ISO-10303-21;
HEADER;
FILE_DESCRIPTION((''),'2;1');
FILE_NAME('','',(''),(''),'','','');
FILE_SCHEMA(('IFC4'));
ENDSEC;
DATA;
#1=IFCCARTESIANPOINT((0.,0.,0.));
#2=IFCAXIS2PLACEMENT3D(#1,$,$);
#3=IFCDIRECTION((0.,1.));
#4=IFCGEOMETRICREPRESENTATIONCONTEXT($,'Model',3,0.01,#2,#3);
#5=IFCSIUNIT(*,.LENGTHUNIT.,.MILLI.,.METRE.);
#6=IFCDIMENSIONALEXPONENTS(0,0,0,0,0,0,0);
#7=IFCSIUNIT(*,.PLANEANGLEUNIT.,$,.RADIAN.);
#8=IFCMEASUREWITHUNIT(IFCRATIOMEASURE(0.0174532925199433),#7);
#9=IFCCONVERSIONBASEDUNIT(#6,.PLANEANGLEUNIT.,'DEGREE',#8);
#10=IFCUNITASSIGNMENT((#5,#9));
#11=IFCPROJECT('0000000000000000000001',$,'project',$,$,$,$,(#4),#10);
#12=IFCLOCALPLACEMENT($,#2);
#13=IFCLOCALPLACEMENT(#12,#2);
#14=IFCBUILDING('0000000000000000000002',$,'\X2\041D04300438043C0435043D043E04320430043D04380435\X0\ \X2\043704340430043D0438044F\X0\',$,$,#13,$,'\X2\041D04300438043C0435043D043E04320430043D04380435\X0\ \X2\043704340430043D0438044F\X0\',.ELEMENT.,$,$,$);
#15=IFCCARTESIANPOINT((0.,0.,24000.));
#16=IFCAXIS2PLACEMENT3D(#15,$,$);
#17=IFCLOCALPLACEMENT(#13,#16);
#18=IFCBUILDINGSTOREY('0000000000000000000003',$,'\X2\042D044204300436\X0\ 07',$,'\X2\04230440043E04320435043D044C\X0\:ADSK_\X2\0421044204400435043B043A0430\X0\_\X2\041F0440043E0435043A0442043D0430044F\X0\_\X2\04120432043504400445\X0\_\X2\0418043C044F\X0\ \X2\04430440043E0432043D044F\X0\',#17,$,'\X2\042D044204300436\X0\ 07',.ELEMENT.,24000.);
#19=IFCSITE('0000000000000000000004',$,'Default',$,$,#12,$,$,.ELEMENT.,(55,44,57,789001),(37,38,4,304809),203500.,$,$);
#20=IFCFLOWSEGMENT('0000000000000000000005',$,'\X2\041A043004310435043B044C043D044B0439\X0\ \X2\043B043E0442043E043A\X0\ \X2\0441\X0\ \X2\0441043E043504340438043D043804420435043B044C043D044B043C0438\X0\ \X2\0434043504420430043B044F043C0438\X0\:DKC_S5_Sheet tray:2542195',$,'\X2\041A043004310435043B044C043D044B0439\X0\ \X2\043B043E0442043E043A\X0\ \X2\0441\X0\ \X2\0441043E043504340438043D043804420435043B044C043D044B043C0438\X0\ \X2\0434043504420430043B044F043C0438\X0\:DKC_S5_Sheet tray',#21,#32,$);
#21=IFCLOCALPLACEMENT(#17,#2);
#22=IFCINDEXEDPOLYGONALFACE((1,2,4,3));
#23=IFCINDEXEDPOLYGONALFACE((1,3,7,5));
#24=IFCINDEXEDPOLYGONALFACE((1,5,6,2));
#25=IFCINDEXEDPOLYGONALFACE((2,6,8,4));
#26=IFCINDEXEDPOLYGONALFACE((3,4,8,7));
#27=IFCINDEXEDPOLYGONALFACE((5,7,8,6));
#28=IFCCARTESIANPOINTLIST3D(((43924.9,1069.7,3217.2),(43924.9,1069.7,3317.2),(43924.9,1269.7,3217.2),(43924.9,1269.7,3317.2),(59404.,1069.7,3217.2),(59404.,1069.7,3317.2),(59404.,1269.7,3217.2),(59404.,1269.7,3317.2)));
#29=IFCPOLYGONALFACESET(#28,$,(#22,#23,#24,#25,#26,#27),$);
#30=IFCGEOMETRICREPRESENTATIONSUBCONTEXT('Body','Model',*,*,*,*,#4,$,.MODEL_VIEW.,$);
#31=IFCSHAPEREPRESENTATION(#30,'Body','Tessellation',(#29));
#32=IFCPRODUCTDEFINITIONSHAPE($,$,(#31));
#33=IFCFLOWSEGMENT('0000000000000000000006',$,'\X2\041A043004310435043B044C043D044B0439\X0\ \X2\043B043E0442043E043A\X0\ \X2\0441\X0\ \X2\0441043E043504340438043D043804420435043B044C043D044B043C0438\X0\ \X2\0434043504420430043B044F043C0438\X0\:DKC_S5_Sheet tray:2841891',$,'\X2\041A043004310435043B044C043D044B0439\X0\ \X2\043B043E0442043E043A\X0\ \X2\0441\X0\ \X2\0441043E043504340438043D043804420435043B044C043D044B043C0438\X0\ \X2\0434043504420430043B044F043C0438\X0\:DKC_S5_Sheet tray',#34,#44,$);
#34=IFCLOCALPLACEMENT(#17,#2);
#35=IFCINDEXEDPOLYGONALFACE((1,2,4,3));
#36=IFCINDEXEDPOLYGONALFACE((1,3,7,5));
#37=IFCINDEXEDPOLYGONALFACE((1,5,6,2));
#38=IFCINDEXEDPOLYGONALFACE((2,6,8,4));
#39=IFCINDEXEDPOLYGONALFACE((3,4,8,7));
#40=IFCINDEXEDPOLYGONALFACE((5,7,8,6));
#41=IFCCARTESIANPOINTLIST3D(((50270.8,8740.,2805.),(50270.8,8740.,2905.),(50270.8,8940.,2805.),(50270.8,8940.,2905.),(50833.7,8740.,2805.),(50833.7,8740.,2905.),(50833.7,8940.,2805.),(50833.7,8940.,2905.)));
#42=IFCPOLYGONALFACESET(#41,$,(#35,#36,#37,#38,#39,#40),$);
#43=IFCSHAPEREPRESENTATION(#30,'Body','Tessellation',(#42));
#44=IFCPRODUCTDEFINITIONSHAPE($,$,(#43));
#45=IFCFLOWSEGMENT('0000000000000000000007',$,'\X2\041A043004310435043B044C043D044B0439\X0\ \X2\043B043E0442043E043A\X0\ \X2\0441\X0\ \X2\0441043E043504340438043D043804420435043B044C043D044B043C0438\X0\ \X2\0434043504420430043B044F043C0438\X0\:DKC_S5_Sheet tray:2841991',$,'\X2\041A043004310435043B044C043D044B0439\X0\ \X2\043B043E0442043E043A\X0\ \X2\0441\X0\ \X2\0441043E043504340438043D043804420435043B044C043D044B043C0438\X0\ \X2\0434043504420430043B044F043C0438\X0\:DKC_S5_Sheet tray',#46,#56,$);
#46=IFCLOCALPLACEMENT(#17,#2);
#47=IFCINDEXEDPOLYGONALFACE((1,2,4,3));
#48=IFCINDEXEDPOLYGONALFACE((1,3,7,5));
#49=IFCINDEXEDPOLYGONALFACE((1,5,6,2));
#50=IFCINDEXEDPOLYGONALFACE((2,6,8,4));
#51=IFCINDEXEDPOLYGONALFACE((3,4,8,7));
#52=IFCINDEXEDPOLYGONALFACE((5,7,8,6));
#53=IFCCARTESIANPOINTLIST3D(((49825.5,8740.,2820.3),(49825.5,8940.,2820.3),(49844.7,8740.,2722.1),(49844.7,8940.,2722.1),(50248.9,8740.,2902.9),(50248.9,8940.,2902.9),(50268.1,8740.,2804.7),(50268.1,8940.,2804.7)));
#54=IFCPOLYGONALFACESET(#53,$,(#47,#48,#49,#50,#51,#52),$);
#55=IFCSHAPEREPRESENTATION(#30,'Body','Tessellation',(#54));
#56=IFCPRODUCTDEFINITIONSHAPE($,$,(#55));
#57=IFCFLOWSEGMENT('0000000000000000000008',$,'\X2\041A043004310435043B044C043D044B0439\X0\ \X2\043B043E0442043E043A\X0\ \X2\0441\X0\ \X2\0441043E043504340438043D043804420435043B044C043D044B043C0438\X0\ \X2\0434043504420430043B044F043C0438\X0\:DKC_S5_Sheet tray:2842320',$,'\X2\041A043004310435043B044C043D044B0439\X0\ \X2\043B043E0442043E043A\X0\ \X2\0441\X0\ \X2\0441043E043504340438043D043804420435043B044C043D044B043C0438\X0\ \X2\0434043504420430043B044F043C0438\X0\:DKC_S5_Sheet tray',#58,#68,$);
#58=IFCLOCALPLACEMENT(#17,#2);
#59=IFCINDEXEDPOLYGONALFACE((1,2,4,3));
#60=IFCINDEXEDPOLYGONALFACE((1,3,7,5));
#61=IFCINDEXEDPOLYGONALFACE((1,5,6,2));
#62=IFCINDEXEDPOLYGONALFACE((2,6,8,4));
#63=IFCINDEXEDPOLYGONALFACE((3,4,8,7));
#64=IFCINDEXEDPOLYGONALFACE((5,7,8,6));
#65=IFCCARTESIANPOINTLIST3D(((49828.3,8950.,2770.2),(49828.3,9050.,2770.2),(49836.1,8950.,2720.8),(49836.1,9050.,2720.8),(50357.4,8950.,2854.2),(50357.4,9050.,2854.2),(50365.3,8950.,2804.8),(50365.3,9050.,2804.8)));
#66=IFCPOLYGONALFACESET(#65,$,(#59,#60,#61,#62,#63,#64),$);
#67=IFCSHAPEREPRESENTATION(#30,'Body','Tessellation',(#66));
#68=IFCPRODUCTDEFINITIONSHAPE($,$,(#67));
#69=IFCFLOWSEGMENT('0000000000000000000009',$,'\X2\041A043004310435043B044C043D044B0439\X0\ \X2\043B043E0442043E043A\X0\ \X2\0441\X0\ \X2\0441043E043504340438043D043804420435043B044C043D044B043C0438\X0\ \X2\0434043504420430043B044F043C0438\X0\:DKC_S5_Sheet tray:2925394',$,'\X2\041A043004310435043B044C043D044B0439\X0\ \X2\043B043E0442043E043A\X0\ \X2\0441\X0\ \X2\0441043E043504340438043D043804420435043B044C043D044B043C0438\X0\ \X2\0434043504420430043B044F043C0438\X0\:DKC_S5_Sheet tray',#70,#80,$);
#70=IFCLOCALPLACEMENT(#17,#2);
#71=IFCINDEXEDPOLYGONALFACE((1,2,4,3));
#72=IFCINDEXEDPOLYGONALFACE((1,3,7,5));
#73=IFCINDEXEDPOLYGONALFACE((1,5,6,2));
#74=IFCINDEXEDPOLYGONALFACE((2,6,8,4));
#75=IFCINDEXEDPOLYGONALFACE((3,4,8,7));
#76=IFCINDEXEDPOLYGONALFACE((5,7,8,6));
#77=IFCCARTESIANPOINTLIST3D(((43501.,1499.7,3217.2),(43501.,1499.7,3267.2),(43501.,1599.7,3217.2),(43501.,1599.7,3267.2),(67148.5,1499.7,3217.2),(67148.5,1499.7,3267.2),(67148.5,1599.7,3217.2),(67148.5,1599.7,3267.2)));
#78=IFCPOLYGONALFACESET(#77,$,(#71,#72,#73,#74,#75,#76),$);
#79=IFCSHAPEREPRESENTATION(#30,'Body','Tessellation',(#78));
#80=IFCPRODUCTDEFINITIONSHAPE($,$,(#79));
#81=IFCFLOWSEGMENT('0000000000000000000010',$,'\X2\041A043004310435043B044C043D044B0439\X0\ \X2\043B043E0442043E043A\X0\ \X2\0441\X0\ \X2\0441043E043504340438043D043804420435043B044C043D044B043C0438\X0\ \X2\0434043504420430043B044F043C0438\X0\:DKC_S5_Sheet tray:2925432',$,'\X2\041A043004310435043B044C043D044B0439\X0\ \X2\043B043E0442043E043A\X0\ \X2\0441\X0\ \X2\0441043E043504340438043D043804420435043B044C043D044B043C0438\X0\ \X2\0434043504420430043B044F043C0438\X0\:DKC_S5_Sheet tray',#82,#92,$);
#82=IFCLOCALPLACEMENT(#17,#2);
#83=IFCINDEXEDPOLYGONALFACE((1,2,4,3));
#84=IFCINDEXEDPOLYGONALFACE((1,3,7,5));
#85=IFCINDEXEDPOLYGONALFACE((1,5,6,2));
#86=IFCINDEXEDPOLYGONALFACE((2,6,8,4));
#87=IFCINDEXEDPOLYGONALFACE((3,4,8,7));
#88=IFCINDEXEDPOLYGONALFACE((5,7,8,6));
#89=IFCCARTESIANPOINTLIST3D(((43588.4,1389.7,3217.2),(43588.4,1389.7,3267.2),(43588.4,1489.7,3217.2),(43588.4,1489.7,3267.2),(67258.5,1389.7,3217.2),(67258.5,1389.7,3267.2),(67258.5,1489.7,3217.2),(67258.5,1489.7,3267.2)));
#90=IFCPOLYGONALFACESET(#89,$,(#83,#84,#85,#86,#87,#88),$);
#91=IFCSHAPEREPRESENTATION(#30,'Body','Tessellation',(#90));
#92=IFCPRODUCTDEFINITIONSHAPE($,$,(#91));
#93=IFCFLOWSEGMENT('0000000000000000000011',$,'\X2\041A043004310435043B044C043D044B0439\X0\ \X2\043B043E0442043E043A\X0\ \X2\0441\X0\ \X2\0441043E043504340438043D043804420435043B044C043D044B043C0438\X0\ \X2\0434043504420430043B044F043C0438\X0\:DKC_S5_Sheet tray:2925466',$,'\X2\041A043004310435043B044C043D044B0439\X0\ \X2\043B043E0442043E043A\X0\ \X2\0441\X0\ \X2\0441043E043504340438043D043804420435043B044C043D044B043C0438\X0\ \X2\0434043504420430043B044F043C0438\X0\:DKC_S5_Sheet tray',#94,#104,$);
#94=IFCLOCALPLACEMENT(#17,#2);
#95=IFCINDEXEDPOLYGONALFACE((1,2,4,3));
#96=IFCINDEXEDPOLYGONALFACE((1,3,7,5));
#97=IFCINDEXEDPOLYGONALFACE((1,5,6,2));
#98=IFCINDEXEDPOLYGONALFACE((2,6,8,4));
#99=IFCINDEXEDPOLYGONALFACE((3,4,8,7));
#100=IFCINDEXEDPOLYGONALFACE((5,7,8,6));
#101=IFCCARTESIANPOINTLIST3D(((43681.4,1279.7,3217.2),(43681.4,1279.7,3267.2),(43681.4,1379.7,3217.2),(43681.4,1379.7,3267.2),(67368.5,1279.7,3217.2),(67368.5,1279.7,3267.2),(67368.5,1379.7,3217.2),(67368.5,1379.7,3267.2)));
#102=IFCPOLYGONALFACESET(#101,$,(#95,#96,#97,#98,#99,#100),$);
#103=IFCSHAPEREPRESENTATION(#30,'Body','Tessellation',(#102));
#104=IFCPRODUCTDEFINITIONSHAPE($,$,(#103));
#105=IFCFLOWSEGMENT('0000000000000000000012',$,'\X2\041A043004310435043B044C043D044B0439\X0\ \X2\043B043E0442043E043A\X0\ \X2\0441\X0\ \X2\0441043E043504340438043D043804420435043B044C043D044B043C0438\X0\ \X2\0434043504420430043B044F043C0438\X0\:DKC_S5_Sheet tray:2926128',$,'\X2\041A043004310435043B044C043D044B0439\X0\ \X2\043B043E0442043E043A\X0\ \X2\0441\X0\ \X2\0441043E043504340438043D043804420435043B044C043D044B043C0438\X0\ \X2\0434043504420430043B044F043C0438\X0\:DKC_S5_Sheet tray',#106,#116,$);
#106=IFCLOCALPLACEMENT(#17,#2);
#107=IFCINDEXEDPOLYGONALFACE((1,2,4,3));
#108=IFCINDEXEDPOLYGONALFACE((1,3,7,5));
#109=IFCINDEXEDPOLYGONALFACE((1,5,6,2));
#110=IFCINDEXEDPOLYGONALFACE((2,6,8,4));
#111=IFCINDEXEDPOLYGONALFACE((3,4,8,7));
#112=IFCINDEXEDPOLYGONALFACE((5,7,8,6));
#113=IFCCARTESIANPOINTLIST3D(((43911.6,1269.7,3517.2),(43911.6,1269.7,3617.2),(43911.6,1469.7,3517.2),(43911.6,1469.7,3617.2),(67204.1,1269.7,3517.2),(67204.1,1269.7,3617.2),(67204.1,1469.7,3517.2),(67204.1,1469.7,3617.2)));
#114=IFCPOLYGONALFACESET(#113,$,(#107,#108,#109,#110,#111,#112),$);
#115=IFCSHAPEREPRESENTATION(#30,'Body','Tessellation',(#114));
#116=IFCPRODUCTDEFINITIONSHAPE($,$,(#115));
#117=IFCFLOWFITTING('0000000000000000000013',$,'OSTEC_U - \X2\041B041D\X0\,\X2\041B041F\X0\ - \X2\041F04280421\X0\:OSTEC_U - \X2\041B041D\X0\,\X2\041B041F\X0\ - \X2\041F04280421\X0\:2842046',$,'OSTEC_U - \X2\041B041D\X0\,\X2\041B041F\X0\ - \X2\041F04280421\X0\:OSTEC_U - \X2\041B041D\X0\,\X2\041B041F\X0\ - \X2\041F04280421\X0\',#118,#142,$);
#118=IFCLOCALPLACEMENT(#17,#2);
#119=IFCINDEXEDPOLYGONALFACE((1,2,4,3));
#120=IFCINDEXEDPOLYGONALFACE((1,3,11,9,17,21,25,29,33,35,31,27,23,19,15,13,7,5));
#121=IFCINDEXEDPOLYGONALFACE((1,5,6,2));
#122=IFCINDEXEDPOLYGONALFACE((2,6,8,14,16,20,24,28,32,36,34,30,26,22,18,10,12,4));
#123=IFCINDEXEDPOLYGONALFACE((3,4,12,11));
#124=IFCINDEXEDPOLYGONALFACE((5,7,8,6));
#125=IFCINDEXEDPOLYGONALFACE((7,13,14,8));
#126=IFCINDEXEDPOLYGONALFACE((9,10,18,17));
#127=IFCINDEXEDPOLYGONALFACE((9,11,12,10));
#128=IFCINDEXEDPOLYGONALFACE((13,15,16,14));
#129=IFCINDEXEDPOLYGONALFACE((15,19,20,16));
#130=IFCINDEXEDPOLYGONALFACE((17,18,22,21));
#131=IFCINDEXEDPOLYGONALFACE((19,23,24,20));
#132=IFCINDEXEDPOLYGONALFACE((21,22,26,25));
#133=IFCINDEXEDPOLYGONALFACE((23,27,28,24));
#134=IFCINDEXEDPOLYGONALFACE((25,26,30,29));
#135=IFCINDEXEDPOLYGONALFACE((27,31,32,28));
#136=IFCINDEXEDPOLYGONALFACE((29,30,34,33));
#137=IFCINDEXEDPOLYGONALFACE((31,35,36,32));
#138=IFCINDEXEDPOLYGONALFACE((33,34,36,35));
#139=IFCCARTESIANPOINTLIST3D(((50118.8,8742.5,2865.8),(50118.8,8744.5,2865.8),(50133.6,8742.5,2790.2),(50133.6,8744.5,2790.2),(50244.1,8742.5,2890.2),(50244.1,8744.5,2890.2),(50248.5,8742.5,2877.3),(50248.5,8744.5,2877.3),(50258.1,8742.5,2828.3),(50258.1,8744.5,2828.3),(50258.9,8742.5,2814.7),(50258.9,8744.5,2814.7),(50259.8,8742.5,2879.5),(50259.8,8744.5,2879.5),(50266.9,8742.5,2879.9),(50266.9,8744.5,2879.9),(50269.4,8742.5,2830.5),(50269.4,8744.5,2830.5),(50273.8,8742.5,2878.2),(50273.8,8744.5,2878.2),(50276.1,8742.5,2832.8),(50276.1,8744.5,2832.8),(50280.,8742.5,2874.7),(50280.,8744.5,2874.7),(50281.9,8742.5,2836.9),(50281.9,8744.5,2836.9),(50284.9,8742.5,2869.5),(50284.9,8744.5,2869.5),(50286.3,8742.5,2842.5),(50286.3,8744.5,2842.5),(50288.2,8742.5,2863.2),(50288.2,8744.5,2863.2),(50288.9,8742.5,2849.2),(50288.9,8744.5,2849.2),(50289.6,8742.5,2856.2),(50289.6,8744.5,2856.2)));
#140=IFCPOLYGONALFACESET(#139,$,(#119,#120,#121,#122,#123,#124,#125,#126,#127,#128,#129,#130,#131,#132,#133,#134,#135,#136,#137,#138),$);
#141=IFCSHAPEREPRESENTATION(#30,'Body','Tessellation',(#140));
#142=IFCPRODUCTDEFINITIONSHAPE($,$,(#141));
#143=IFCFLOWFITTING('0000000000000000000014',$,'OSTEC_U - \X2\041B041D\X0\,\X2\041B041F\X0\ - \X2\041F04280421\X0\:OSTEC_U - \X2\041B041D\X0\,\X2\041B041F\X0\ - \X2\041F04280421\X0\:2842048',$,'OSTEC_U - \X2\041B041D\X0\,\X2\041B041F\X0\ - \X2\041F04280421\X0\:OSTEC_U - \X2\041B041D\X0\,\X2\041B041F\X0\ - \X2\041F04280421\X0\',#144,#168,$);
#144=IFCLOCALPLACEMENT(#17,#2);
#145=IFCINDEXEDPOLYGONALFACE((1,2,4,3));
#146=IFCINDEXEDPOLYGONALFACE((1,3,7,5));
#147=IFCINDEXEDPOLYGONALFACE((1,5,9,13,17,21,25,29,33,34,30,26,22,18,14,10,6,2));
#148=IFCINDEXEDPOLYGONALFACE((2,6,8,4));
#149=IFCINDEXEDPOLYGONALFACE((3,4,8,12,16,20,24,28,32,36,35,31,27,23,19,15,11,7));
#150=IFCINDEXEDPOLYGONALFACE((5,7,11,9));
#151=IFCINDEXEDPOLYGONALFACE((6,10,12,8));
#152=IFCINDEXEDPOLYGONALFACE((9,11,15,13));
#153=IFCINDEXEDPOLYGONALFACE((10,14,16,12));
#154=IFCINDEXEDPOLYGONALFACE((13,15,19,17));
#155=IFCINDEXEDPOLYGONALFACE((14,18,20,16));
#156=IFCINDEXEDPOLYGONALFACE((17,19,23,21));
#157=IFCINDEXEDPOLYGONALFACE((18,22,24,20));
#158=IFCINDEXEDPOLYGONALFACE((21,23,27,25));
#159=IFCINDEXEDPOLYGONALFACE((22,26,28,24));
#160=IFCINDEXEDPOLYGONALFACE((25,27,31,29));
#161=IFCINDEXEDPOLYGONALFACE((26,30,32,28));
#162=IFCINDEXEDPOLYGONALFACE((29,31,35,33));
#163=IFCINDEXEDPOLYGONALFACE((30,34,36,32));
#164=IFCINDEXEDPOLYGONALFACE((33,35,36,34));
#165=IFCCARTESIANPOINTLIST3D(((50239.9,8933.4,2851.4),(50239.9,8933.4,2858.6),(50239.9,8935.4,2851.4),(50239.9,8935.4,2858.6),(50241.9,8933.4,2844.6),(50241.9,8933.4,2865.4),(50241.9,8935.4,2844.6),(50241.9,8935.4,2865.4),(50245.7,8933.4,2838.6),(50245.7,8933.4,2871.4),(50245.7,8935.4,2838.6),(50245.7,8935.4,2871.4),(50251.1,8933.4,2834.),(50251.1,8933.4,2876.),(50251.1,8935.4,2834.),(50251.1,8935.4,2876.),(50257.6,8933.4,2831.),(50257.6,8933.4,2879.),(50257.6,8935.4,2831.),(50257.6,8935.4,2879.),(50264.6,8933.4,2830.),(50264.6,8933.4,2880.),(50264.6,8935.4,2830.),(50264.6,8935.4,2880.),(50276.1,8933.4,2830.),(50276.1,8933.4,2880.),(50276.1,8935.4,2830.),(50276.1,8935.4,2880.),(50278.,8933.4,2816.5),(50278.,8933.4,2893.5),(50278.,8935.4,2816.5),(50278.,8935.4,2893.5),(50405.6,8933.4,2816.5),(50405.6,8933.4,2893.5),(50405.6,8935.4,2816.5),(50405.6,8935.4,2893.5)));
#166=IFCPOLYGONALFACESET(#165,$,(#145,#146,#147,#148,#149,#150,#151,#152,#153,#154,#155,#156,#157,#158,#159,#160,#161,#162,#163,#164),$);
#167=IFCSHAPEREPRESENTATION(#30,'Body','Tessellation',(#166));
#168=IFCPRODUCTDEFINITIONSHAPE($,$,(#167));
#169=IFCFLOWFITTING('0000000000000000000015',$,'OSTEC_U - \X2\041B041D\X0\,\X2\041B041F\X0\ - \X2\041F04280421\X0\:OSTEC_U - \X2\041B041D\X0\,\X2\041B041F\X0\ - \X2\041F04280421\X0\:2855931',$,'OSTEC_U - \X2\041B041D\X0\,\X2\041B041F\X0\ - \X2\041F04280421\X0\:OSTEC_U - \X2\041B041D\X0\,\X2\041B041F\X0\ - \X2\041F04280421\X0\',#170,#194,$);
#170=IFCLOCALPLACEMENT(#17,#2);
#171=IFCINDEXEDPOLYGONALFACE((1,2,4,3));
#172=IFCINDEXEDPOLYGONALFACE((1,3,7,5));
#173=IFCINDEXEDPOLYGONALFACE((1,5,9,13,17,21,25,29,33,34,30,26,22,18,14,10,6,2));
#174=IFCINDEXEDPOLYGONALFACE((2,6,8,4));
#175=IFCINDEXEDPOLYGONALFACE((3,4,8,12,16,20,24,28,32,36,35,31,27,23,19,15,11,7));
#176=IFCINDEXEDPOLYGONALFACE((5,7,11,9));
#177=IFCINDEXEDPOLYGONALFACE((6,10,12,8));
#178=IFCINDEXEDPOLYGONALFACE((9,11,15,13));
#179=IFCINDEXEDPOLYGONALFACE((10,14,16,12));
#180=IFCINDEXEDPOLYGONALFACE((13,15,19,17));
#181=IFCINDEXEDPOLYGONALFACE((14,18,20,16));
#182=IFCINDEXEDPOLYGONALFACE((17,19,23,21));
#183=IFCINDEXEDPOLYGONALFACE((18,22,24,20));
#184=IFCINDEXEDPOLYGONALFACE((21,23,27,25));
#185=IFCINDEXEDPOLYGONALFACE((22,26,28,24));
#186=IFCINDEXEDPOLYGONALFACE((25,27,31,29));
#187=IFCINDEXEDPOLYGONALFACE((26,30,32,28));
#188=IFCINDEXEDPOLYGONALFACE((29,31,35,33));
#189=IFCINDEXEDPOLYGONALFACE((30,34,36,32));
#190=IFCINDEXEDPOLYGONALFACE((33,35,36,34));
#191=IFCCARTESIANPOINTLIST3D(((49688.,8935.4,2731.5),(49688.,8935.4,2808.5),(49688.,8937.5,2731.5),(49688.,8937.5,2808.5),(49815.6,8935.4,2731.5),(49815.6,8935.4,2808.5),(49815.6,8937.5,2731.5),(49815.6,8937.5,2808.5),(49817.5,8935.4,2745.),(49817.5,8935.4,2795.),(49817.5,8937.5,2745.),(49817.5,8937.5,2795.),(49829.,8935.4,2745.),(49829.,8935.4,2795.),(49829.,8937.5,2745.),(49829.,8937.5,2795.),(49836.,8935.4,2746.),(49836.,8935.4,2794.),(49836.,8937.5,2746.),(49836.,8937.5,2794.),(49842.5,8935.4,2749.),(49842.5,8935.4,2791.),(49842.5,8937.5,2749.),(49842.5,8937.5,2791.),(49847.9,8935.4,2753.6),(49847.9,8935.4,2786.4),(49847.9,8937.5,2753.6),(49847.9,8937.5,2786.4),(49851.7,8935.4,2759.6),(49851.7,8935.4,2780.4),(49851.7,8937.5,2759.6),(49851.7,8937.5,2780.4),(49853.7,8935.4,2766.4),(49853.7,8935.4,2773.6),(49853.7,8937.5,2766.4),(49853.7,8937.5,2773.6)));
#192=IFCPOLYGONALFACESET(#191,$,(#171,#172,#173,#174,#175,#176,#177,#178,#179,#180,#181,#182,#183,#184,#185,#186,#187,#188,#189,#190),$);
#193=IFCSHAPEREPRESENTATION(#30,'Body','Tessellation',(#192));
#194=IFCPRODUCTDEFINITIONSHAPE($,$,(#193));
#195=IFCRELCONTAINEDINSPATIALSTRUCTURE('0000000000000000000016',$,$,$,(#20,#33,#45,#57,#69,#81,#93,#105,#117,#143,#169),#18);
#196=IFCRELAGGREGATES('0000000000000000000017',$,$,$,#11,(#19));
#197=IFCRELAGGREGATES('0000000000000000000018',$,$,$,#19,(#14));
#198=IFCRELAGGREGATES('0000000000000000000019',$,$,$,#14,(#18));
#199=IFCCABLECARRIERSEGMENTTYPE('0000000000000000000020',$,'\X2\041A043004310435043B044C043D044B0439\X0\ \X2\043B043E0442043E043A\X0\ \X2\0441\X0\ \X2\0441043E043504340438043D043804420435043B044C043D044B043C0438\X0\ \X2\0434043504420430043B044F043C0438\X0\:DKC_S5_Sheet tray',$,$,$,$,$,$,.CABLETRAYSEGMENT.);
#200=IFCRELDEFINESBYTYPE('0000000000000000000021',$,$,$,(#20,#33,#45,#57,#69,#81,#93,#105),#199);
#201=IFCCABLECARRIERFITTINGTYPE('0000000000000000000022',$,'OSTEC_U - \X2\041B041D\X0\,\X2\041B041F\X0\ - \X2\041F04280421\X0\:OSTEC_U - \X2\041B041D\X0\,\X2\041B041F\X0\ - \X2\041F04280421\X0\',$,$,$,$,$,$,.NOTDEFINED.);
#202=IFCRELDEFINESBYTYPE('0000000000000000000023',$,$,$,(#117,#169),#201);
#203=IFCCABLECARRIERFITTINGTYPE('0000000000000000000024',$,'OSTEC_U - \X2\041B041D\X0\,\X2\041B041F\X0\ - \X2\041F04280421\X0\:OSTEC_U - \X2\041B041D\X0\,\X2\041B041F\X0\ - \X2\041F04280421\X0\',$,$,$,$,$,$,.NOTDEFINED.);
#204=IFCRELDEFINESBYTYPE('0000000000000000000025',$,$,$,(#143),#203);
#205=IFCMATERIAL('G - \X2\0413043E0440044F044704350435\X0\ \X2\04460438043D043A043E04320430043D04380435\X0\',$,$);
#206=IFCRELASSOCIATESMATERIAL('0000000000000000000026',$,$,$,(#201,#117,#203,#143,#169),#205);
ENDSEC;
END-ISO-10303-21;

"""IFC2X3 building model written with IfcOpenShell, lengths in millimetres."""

from ifc_helpers import new_model, entity, si_unit, converted_unit, direction, frame, frame_2d, origin, origin_2d_with_axis, place, context, subcontext, project, spatial, polyline, circle_curve, parameter, trimmed, segment, composite_curve, rectangle, outline, extrude, source, transform, mapped, material, type_object, type_shapes, element, save


model = new_model("IFC2X3")

# Units and contexts
model_context = context("Model", 3, precision=0.01, world=origin(), true_north=direction((0.0, 1.0)))
body_context = subcontext(model_context, "Body", "Model", "MODEL_VIEW")
ifc_project = project(units=[si_unit("LENGTHUNIT", "METRE", prefix="MILLI"), converted_unit("PLANEANGLEUNIT", "DEGREE", entity("IfcRatioMeasure", 0.0174532925199433), si_unit("PLANEANGLEUNIT", "RADIAN"), dimensions=[0, 0, 0, 0, 0, 0, 0])], contexts=[model_context])

# Site, building, storey
site_placement = place(None, origin())
site = spatial("IfcSite", under=ifc_project, at=site_placement, Name="Default", CompositionType="ELEMENT", RefLatitude=(55, 44, 57, 789001), RefLongitude=(37, 38, 4, 304809), RefElevation=203500.0)
building_placement = place(site_placement, origin())
building = spatial("IfcBuilding", under=site, at=building_placement, Name="Наименование здания", LongName="Наименование здания", CompositionType="ELEMENT")
storey_placement = place(building_placement, frame((0.0, 0.0, 24000.0)))
storey = spatial("IfcBuildingStorey", under=building, at=storey_placement, Name="Этаж 07", ObjectType="Уровень:ADSK_Стрелка_Проектная_Вверх_Имя уровня", LongName="Этаж 07", CompositionType="ELEMENT", Elevation=24000.0)

# Flow segments
cable_carrier_segment_type = type_object("IfcCableCarrierSegmentType", Name="Кабельный лоток с соединительными деталями:DKC_S5_Sheet tray", PredefinedType="CABLETRAYSEGMENT")
flow_segment_1_placement = place(storey_placement, frame((43924.9, 1069.7, 3217.2)))
element("IfcFlowSegment", 1, at=flow_segment_1_placement, inside=storey, type_object=cable_carrier_segment_type, Name="Кабельный лоток с соединительными деталями:DKC_S5_Sheet tray:2542195", ObjectType="Кабельный лоток с соединительными деталями:DKC_S5_Sheet tray", context=body_context, shape_type="SweptSolid", body=[
    extrude(rectangle(XDim=15479.1, YDim=200.0, at=origin_2d_with_axis()), frame((7739.6, 100.0, 0.0), z_axis=(0.0, 0.0, 1.0), x_axis=(-1.0, 0.0, 0.0)), (0.0, 0.0, 1.0), 100.0),
])
flow_segment_2_placement = place(storey_placement, frame((50270.8, 8740.0, 2805.0)))
element("IfcFlowSegment", 2, at=flow_segment_2_placement, inside=storey, type_object=cable_carrier_segment_type, Name="Кабельный лоток с соединительными деталями:DKC_S5_Sheet tray:2841891", ObjectType="Кабельный лоток с соединительными деталями:DKC_S5_Sheet tray", context=body_context, shape_type="SweptSolid", body=[
    extrude(rectangle(XDim=562.9, YDim=200.0, at=origin_2d_with_axis()), frame((281.4, 100.0, 0.0)), (0.0, 0.0, 1.0), 100.0),
])
flow_segment_3_placement = place(storey_placement, frame((49825.5, 8740.0, 2722.1)))
element("IfcFlowSegment", 3, at=flow_segment_3_placement, inside=storey, type_object=cable_carrier_segment_type, Name="Кабельный лоток с соединительными деталями:DKC_S5_Sheet tray:2841991", ObjectType="Кабельный лоток с соединительными деталями:DKC_S5_Sheet tray", context=body_context, shape_type="SweptSolid", body=[
    extrude(rectangle(XDim=100.0, YDim=200.0, at=origin_2d_with_axis()), frame((9.6, 100.0, 49.1), z_axis=(0.981491, 0.0, 0.191508), x_axis=(-0.191508, 0.0, 0.981491)), (0.0, 0.0, 1.0), 431.4),
])
flow_segment_4_placement = place(storey_placement, frame((49828.3, 8950.0, 2720.8)))
element("IfcFlowSegment", 4, at=flow_segment_4_placement, inside=storey, type_object=cable_carrier_segment_type, Name="Кабельный лоток с соединительными деталями:DKC_S5_Sheet tray:2842320", ObjectType="Кабельный лоток с соединительными деталями:DKC_S5_Sheet tray", context=body_context, shape_type="SweptSolid", body=[
    extrude(rectangle(XDim=50.0, YDim=100.0, at=origin_2d_with_axis()), frame((3.9, 50.0, 24.7), z_axis=(0.987641, 0.0, 0.15673), x_axis=(-0.15673, 0.0, 0.987641)), (0.0, 0.0, 1.0), 535.8),
])
flow_segment_5_placement = place(storey_placement, frame((43501.0, 1499.7, 3217.2)))
element("IfcFlowSegment", 5, at=flow_segment_5_placement, inside=storey, type_object=cable_carrier_segment_type, Name="Кабельный лоток с соединительными деталями:DKC_S5_Sheet tray:2925394", ObjectType="Кабельный лоток с соединительными деталями:DKC_S5_Sheet tray", context=body_context, shape_type="SweptSolid", body=[
    extrude(rectangle(XDim=23647.5, YDim=100.0, at=origin_2d_with_axis()), frame((11823.7, 50.0, 0.0)), (0.0, 0.0, 1.0), 50.0),
])
flow_segment_6_placement = place(storey_placement, frame((43588.4, 1389.7, 3217.2)))
element("IfcFlowSegment", 6, at=flow_segment_6_placement, inside=storey, type_object=cable_carrier_segment_type, Name="Кабельный лоток с соединительными деталями:DKC_S5_Sheet tray:2925432", ObjectType="Кабельный лоток с соединительными деталями:DKC_S5_Sheet tray", context=body_context, shape_type="SweptSolid", body=[
    extrude(rectangle(XDim=23670.1, YDim=100.0, at=origin_2d_with_axis()), frame((11835.0, 50.0, 0.0)), (0.0, 0.0, 1.0), 50.0),
])
flow_segment_7_placement = place(storey_placement, frame((43681.4, 1279.7, 3217.2)))
element("IfcFlowSegment", 7, at=flow_segment_7_placement, inside=storey, type_object=cable_carrier_segment_type, Name="Кабельный лоток с соединительными деталями:DKC_S5_Sheet tray:2925466", ObjectType="Кабельный лоток с соединительными деталями:DKC_S5_Sheet tray", context=body_context, shape_type="SweptSolid", body=[
    extrude(rectangle(XDim=23687.1, YDim=100.0, at=origin_2d_with_axis()), frame((11843.5, 50.0, 0.0)), (0.0, 0.0, 1.0), 50.0),
])
flow_segment_8_placement = place(storey_placement, frame((43911.6, 1269.7, 3517.2)))
element("IfcFlowSegment", 8, at=flow_segment_8_placement, inside=storey, type_object=cable_carrier_segment_type, Name="Кабельный лоток с соединительными деталями:DKC_S5_Sheet tray:2926128", ObjectType="Кабельный лоток с соединительными деталями:DKC_S5_Sheet tray", context=body_context, shape_type="SweptSolid", body=[
    extrude(rectangle(XDim=23292.5, YDim=200.0, at=origin_2d_with_axis()), frame((11646.3, 100.0, 0.0)), (0.0, 0.0, 1.0), 100.0),
])

# Flow fittings
ifc_material_1 = material(Name="G - Горячее цинкование")
cable_carrier_fitting_type_1 = type_object("IfcCableCarrierFittingType", Name="OSTEC_U - ЛН,ЛП - ПШС:OSTEC_U - ЛН,ЛП - ПШС", PredefinedType="NOTDEFINED", material=ifc_material_1)
shared_shape_1 = source(origin(), body_context, "Body", "SweptSolid", [
    extrude(outline(composite_curve([segment(trimmed(circle_curve(frame_2d((-41.5, 0.0), x_axis=(1.0, 0.0)), 25.0), [parameter(90.0)], [parameter(270.0)], True, "PARAMETER"), True, "CONTINUOUS"), segment(polyline([(-41.5, -25.0), (-30.0, -25.0)]), True, "CONTINUOUS"), segment(polyline([(-30.0, -25.0), (-28.1, -38.5)]), True, "CONTINUOUS"), segment(polyline([(-28.1, -38.5), (99.5, -38.5)]), True, "CONTINUOUS"), segment(polyline([(99.5, -38.5), (99.5, 38.5)]), True, "CONTINUOUS"), segment(polyline([(99.5, 38.5), (-28.1, 38.5)]), True, "CONTINUOUS"), segment(polyline([(-28.1, 38.5), (-30.0, 25.0)]), True, "CONTINUOUS"), segment(polyline([(-30.0, 25.0), (-41.5, 25.0)]), True, "CONTINUOUS")], self_intersect=False)), frame((41.5, 0.0, 0.0), z_axis=(0.0, 0.0, -1.0), x_axis=(1.0, 0.0, 0.0)), (0.0, 0.0, -1.0), 2.0),
])
type_shapes(cable_carrier_fitting_type_1, [shared_shape_1])
flow_fitting_1_placement = place(storey_placement, frame((50264.6, 8744.5, 2855.0), z_axis=(0.0, -1.0, 0.0), x_axis=(-0.981491, 0.0, -0.191508)))
element("IfcFlowFitting", 9, at=flow_fitting_1_placement, inside=storey, type_object=cable_carrier_fitting_type_1, material=ifc_material_1, Name="OSTEC_U - ЛН,ЛП - ПШС:OSTEC_U - ЛН,ЛП - ПШС:2842046", ObjectType="OSTEC_U - ЛН,ЛП - ПШС:OSTEC_U - ЛН,ЛП - ПШС", context=body_context, shape_type="MappedRepresentation", body=[
    mapped(shared_shape_1, transform((0.0, 0.0, 0.0), scale=1.0)),
])
cable_carrier_fitting_type_2 = type_object("IfcCableCarrierFittingType", Name="OSTEC_U - ЛН,ЛП - ПШС:OSTEC_U - ЛН,ЛП - ПШС", PredefinedType="NOTDEFINED", material=ifc_material_1)
type_shapes(cable_carrier_fitting_type_2, [shared_shape_1])
flow_fitting_2_placement = place(storey_placement, frame((50264.6, 8933.5, 2855.0), z_axis=(0.0, 1.0, 0.0), x_axis=(1.0, 0.0, 0.0)))
element("IfcFlowFitting", 10, at=flow_fitting_2_placement, inside=storey, type_object=cable_carrier_fitting_type_2, material=ifc_material_1, Name="OSTEC_U - ЛН,ЛП - ПШС:OSTEC_U - ЛН,ЛП - ПШС:2842048", ObjectType="OSTEC_U - ЛН,ЛП - ПШС:OSTEC_U - ЛН,ЛП - ПШС", context=body_context, shape_type="MappedRepresentation", body=[
    mapped(shared_shape_1, transform((0.0, 0.0, 0.0), scale=1.0)),
])
flow_fitting_3_placement = place(storey_placement, frame((49829.0, 8935.5, 2770.0), z_axis=(0.0, 1.0, 0.0), x_axis=(-1.0, 0.0, 0.0)))
element("IfcFlowFitting", 11, at=flow_fitting_3_placement, inside=storey, type_object=cable_carrier_fitting_type_1, material=ifc_material_1, Name="OSTEC_U - ЛН,ЛП - ПШС:OSTEC_U - ЛН,ЛП - ПШС:2855931", ObjectType="OSTEC_U - ЛН,ЛП - ПШС:OSTEC_U - ЛН,ЛП - ПШС", context=body_context, shape_type="MappedRepresentation", body=[
    mapped(shared_shape_1, transform((0.0, 0.0, 0.0), scale=1.0)),
])

save(model, "model.ifc")
